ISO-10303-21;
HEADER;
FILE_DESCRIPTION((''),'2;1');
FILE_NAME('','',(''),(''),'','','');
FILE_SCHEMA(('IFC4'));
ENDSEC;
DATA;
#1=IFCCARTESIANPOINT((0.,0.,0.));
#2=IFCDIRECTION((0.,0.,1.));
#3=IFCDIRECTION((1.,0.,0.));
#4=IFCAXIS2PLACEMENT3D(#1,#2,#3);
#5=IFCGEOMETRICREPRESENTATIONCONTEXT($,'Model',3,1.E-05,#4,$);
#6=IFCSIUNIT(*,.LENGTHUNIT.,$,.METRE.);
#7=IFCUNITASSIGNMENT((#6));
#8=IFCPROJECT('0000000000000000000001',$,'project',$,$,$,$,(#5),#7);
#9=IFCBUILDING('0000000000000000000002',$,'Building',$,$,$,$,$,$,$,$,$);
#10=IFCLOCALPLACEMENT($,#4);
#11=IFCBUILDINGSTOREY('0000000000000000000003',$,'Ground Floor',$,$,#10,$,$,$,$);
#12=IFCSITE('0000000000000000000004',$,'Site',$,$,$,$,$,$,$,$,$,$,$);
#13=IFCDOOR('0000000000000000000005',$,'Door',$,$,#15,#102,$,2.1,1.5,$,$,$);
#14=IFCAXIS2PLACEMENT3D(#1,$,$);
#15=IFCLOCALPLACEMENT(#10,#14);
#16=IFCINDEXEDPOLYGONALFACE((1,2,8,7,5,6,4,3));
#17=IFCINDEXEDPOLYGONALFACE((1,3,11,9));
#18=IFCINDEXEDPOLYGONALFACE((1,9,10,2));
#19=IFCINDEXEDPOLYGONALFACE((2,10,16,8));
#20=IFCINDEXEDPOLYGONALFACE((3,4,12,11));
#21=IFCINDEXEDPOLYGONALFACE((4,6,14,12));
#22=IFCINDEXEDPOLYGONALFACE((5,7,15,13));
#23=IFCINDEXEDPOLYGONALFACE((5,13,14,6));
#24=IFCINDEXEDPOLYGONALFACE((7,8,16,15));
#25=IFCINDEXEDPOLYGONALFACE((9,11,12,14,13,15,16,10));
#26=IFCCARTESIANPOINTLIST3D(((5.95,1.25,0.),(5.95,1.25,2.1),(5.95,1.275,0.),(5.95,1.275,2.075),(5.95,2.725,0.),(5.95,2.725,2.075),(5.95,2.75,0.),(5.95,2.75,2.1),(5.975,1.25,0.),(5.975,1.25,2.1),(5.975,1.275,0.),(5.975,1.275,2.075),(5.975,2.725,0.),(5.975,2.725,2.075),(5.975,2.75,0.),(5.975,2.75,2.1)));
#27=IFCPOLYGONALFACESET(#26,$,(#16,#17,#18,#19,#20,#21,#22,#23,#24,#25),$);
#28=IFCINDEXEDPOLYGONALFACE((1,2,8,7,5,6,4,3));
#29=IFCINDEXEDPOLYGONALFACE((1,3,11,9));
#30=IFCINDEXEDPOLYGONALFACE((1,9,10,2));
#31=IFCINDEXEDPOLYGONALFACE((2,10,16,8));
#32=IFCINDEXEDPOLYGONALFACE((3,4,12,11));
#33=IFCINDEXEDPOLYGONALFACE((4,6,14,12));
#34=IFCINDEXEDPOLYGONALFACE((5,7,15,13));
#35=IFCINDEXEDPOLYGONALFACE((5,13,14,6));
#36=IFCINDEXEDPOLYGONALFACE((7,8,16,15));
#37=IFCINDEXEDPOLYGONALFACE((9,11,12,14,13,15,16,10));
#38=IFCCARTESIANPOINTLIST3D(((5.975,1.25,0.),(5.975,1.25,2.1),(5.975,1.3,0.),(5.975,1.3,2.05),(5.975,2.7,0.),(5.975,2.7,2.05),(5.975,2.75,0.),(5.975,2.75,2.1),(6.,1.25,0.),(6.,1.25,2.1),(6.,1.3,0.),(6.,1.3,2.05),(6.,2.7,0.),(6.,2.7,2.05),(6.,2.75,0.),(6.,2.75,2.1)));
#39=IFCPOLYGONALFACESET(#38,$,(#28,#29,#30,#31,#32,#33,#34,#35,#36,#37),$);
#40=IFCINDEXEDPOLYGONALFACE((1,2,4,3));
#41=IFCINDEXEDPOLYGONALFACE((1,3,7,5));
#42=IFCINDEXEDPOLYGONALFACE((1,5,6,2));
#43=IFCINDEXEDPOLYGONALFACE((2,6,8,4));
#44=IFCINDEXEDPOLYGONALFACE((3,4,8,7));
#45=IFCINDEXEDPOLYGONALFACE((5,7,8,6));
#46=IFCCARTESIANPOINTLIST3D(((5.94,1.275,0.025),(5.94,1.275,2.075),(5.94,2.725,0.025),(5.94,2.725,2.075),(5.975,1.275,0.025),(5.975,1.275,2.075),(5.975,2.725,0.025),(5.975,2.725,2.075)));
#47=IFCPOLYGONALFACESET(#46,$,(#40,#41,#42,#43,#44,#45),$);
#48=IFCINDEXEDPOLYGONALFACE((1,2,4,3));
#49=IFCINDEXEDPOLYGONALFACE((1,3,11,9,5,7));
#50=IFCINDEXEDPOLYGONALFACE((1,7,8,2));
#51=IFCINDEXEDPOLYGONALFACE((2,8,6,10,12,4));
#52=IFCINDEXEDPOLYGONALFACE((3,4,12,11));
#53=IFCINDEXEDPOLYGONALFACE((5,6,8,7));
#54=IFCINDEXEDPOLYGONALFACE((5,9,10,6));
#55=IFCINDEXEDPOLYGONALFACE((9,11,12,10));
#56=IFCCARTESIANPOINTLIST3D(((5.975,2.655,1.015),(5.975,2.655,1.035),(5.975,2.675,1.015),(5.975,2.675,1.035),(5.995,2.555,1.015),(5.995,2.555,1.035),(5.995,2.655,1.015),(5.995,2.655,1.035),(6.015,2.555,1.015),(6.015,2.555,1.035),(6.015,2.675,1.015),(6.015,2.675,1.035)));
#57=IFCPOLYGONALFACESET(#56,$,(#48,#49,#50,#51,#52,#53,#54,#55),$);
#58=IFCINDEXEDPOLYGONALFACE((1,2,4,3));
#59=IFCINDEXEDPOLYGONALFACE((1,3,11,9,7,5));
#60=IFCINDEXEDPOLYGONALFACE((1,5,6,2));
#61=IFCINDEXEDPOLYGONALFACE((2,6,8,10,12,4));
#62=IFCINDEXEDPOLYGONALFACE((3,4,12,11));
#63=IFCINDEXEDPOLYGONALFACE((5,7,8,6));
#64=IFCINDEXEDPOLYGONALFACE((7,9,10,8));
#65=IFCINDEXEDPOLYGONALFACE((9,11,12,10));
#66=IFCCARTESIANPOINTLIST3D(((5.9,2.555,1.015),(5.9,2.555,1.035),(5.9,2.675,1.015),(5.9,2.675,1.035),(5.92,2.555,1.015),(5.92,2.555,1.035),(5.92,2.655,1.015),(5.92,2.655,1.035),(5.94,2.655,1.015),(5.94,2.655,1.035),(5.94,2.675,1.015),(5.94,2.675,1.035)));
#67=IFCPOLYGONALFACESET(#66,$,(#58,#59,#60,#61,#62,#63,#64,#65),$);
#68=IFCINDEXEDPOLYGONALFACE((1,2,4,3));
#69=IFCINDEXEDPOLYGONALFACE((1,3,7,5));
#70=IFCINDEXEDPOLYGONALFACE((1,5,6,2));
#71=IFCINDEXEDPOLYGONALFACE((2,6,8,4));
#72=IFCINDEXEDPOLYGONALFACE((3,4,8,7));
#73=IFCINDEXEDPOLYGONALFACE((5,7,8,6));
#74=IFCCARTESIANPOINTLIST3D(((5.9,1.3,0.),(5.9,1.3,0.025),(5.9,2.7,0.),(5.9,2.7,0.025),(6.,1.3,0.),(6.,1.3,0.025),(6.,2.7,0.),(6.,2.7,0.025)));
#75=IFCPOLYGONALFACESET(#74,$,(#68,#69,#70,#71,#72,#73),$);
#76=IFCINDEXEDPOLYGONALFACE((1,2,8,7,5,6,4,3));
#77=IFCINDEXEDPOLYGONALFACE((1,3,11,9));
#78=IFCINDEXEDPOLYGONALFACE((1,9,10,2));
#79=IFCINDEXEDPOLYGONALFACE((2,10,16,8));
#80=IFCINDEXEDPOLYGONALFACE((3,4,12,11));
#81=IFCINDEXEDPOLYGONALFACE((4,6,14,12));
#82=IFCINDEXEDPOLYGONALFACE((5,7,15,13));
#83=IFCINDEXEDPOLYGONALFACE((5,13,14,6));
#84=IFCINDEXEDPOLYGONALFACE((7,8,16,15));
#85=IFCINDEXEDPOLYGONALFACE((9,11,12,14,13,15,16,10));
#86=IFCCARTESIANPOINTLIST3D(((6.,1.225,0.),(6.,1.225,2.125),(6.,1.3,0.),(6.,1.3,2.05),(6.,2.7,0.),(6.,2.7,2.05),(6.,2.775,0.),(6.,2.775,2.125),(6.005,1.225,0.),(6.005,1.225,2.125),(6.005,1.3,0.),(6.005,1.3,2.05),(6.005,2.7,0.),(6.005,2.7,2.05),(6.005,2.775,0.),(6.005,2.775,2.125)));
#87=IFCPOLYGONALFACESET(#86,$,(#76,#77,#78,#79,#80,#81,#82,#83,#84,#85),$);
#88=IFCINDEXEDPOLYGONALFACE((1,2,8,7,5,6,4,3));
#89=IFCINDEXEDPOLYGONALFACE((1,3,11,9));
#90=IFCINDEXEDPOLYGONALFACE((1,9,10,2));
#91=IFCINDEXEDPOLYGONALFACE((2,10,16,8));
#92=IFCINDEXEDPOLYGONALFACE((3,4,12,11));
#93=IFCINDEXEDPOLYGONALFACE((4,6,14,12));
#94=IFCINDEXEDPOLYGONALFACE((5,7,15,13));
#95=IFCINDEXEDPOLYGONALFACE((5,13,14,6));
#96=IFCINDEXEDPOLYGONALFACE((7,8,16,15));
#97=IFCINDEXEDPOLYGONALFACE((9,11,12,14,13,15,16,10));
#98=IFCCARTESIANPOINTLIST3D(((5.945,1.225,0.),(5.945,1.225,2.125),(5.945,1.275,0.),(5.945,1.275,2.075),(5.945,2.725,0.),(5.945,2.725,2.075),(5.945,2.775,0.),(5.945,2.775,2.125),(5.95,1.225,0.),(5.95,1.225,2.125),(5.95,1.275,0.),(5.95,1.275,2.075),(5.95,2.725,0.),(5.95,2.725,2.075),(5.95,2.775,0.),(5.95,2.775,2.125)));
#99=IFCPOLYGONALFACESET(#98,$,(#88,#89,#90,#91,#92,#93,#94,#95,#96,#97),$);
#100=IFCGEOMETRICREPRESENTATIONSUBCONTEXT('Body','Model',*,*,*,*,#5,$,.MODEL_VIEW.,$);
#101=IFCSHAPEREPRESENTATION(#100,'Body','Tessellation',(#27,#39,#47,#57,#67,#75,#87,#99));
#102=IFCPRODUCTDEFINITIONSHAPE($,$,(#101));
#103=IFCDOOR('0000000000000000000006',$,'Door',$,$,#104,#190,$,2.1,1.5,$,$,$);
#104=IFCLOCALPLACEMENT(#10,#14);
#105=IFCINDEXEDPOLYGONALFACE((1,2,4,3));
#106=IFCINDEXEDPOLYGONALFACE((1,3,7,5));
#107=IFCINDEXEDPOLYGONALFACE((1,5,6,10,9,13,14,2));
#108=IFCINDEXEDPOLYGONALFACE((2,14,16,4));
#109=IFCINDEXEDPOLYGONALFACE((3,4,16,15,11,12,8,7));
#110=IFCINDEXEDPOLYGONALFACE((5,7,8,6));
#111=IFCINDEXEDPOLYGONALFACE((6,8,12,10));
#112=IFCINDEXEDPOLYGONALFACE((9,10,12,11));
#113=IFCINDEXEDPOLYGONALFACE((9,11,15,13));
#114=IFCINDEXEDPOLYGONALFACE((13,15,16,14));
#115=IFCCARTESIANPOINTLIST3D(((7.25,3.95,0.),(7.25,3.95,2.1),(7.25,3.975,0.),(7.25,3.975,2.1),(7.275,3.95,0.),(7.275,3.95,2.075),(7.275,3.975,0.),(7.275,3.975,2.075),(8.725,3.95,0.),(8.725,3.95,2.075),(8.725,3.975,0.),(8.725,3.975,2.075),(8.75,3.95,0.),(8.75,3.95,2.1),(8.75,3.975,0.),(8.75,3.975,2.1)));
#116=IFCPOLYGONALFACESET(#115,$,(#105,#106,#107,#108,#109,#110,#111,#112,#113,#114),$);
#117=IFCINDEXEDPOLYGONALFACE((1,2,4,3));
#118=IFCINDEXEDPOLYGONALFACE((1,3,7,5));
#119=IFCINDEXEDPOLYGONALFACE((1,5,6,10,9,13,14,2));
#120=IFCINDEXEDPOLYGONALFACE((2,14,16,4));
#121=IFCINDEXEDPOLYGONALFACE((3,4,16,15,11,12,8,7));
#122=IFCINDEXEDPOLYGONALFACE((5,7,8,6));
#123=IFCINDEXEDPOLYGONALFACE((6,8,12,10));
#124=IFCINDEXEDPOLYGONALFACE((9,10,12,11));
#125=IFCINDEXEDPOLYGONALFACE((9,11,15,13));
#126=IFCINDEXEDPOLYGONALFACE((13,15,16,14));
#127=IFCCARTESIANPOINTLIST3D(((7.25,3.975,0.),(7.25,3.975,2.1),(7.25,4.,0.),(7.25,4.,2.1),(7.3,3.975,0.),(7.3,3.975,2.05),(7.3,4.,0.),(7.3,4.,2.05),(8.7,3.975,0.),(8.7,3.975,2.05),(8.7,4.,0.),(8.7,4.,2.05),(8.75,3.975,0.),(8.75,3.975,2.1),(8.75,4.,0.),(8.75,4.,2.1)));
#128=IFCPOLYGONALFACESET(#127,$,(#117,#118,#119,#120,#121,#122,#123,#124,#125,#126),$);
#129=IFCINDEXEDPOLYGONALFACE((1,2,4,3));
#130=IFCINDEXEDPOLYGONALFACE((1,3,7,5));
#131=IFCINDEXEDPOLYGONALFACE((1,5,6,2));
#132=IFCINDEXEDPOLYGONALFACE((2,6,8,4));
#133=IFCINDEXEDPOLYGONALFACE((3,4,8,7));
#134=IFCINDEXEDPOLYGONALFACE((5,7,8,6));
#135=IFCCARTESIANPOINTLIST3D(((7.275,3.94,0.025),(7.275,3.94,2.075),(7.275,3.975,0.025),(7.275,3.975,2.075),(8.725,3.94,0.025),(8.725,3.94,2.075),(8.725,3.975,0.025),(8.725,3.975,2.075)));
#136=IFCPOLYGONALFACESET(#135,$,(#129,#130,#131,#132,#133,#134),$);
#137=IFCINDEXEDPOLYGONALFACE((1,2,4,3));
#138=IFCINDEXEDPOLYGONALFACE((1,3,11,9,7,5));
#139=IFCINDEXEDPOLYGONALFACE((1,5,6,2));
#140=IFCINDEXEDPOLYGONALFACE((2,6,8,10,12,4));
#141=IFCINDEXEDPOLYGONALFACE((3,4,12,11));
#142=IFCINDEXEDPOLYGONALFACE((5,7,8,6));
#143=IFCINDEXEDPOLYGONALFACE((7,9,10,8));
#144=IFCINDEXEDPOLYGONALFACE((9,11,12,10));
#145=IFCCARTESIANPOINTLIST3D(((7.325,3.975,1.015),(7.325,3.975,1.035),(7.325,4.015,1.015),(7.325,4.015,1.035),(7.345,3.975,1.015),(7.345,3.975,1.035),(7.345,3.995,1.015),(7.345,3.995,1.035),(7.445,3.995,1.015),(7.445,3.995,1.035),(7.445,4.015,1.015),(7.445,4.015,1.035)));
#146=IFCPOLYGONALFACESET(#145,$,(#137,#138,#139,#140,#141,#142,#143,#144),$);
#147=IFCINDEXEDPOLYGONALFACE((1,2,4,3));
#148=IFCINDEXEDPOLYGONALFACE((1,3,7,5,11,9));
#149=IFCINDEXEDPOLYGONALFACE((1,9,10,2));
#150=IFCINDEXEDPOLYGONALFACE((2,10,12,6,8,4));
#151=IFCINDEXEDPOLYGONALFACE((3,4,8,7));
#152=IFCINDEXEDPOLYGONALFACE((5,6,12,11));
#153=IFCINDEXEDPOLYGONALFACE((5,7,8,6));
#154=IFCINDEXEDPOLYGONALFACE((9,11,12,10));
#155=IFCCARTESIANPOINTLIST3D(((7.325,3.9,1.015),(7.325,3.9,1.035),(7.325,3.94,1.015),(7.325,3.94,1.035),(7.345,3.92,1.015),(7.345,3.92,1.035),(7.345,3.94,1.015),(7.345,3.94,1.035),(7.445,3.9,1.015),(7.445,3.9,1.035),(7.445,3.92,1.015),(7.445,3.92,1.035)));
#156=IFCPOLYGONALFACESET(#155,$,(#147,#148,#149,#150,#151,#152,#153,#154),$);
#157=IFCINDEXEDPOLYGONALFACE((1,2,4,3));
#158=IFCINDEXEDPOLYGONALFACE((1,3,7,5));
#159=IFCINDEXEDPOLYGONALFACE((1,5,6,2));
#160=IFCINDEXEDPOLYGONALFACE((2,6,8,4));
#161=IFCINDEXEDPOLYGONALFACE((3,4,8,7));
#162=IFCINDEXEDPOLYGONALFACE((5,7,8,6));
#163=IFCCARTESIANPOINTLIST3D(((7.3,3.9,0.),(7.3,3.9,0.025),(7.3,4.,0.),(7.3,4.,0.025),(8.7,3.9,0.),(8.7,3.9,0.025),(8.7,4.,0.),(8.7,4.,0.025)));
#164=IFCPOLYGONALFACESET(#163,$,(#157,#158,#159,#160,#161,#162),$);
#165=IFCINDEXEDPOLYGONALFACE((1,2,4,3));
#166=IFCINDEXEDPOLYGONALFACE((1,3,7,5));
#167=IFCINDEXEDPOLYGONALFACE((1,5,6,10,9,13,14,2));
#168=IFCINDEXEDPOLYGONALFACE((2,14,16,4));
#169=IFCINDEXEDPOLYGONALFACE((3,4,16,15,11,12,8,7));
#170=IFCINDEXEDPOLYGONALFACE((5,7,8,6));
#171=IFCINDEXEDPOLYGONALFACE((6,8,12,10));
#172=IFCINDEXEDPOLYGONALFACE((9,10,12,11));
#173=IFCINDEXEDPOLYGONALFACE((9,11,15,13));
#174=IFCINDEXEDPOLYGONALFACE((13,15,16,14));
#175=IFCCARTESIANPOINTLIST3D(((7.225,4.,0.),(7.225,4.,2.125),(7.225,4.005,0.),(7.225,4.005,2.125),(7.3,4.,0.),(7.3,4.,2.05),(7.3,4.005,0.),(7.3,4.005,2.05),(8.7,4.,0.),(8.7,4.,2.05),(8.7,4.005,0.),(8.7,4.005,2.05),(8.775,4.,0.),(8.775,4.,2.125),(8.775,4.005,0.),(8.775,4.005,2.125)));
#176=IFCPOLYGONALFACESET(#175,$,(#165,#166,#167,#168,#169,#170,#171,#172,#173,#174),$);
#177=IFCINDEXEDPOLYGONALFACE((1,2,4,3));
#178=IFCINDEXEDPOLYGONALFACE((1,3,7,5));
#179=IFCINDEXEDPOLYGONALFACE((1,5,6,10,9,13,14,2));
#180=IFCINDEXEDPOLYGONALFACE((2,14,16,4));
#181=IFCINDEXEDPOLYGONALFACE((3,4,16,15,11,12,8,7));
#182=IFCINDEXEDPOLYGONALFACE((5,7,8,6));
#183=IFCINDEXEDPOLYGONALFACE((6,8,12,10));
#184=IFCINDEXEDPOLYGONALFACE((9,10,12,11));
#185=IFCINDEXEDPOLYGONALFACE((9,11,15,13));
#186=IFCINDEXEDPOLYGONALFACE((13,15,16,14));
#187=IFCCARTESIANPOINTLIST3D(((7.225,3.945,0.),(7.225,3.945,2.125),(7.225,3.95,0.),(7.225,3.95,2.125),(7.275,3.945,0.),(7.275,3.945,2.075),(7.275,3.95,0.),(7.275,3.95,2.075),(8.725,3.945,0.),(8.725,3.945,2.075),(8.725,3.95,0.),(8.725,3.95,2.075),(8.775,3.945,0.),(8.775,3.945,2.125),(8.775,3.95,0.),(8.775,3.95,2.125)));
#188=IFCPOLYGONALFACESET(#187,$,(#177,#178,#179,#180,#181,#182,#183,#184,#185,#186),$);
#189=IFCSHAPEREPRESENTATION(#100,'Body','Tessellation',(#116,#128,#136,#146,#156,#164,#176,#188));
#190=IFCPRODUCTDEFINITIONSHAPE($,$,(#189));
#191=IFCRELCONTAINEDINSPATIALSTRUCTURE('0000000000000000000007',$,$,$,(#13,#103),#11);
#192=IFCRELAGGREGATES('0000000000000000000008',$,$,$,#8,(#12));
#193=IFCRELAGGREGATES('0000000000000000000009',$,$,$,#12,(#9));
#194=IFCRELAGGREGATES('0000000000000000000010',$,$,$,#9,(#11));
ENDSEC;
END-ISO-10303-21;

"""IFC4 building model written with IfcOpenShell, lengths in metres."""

from ifc_helpers import new_model, si_unit, frame, origin_with_axes, place, context, subcontext, project, spatial, line, indexed_curve, outline, extrude, element, save


model = new_model("IFC4")

# Units and contexts
model_context = context("Model", 3, precision=1e-05, world=origin_with_axes())
body_context = subcontext(model_context, "Body", "Model", "MODEL_VIEW")
ifc_project = project(units=[si_unit("LENGTHUNIT", "METRE")], contexts=[model_context])

# Site, building, storey
site = spatial("IfcSite", under=ifc_project, Name="Site")
building = spatial("IfcBuilding", under=site, Name="Building")
storey_placement = place(None, origin_with_axes())
storey = spatial("IfcBuildingStorey", under=building, at=storey_placement, Name="Ground Floor")

# Doors
door_1_placement = place(storey_placement, frame((6.0, 1.25, 0.0), z_axis=(0.0, 0.0, 1.0), x_axis=(0.0, 1.0, 0.0)))
element("IfcDoor", 1, at=door_1_placement, inside=storey, Name="Door", OverallHeight=2.1, OverallWidth=1.5, context=body_context, shape_type="SweptSolid", body=[
    extrude(outline(indexed_curve([(0.0, 0.0), (0.0, 2.1), (1.5, 2.1), (1.5, 0.0), (1.475, 0.0), (1.475, 2.075), (0.025, 2.075), (0.025, 0.0)], segments=[line(1, 2, 3, 4, 5, 6, 7, 8, 1)])), frame((0.0, 0.025, 0.0), z_axis=(0.0, -1.0, 0.0), x_axis=(1.0, 0.0, 0.0)), (0.0, 0.0, -1.0), 0.025),
    extrude(outline(indexed_curve([(0.0, 0.0), (0.0, 2.1), (1.5, 2.1), (1.5, 0.0), (1.45, 0.0), (1.45, 2.05), (0.05, 2.05), (0.05, 0.0)], segments=[line(1, 2, 3, 4, 5, 6, 7, 8, 1)])), frame((0.0, 0.0, 0.0), z_axis=(0.0, -1.0, 0.0), x_axis=(1.0, 0.0, 0.0)), (0.0, 0.0, -1.0), 0.025),
    extrude(outline(indexed_curve([(0.0, 0.0), (1.45, 0.0), (1.45, 0.035), (0.0, 0.035)], segments=[line(1, 2, 3, 4, 1)])), frame((0.025, 0.025, 0.025), z_axis=(0.0, 0.0, 1.0), x_axis=(1.0, 0.0, 0.0)), (0.0, 0.0, 1.0), 2.05),
    extrude(outline(indexed_curve([(0.0, 0.0), (0.0, -0.04), (-0.12, -0.04), (-0.12, -0.02), (-0.02, -0.02), (-0.02, 0.0)], segments=[line(1, 2, 3, 4, 5, 6, 1)])), frame((1.425, 0.025, 1.015), z_axis=(0.0, 0.0, 1.0), x_axis=(1.0, 0.0, 0.0)), (0.0, 0.0, 1.0), 0.02),
    extrude(outline(indexed_curve([(0.0, 0.0), (0.0, 0.04), (-0.12, 0.04), (-0.12, 0.02), (-0.02, 0.02), (-0.02, 0.0)], segments=[line(1, 2, 3, 4, 5, 6, 1)])), frame((1.425, 0.06, 1.015), z_axis=(0.0, 0.0, 1.0), x_axis=(1.0, 0.0, 0.0)), (0.0, 0.0, 1.0), 0.02),
    extrude(outline(indexed_curve([(0.0, 0.0), (1.4, 0.0), (1.4, 0.1), (0.0, 0.1)], segments=[line(1, 2, 3, 4, 1)])), frame((0.05, 0.0, 0.0), z_axis=(0.0, 0.0, 1.0), x_axis=(1.0, 0.0, 0.0)), (0.0, 0.0, 1.0), 0.025),
    extrude(outline(indexed_curve([(0.0, 0.0), (0.0, 2.125), (1.55, 2.125), (1.55, 0.0), (1.475, 0.0), (1.475, 2.05), (0.075, 2.05), (0.075, 0.0)], segments=[line(1, 2, 3, 4, 5, 6, 7, 8, 1)])), frame((-0.025, -0.005, 0.0), z_axis=(0.0, -1.0, 0.0), x_axis=(1.0, 0.0, 0.0)), (0.0, 0.0, -1.0), 0.005),
    extrude(outline(indexed_curve([(0.0, 0.0), (0.0, 2.125), (1.55, 2.125), (1.55, 0.0), (1.5, 0.0), (1.5, 2.075), (0.05, 2.075), (0.05, 0.0)], segments=[line(1, 2, 3, 4, 5, 6, 7, 8, 1)])), frame((-0.025, 0.05, 0.0), z_axis=(0.0, -1.0, 0.0), x_axis=(1.0, 0.0, 0.0)), (0.0, 0.0, -1.0), 0.005),
])
door_2_placement = place(storey_placement, frame((8.75, 4.0, 0.0), z_axis=(0.0, 0.0, 1.0), x_axis=(-1.0, 0.0, 0.0)))
element("IfcDoor", 2, at=door_2_placement, inside=storey, Name="Door", OverallHeight=2.1, OverallWidth=1.5, context=body_context, shape_type="SweptSolid", body=[
    extrude(outline(indexed_curve([(0.0, 0.0), (0.0, 2.1), (1.5, 2.1), (1.5, 0.0), (1.475, 0.0), (1.475, 2.075), (0.025, 2.075), (0.025, 0.0)], segments=[line(1, 2, 3, 4, 5, 6, 7, 8, 1)])), frame((0.0, 0.025, 0.0), z_axis=(0.0, -1.0, 0.0), x_axis=(1.0, 0.0, 0.0)), (0.0, 0.0, -1.0), 0.025),
    extrude(outline(indexed_curve([(0.0, 0.0), (0.0, 2.1), (1.5, 2.1), (1.5, 0.0), (1.45, 0.0), (1.45, 2.05), (0.05, 2.05), (0.05, 0.0)], segments=[line(1, 2, 3, 4, 5, 6, 7, 8, 1)])), frame((0.0, 0.0, 0.0), z_axis=(0.0, -1.0, 0.0), x_axis=(1.0, 0.0, 0.0)), (0.0, 0.0, -1.0), 0.025),
    extrude(outline(indexed_curve([(0.0, 0.0), (1.45, 0.0), (1.45, 0.035), (0.0, 0.035)], segments=[line(1, 2, 3, 4, 1)])), frame((0.025, 0.025, 0.025), z_axis=(0.0, 0.0, 1.0), x_axis=(1.0, 0.0, 0.0)), (0.0, 0.0, 1.0), 2.05),
    extrude(outline(indexed_curve([(0.0, 0.0), (0.0, -0.04), (-0.12, -0.04), (-0.12, -0.02), (-0.02, -0.02), (-0.02, 0.0)], segments=[line(1, 2, 3, 4, 5, 6, 1)])), frame((1.425, 0.025, 1.015), z_axis=(0.0, 0.0, 1.0), x_axis=(1.0, 0.0, 0.0)), (0.0, 0.0, 1.0), 0.02),
    extrude(outline(indexed_curve([(0.0, 0.0), (0.0, 0.04), (-0.12, 0.04), (-0.12, 0.02), (-0.02, 0.02), (-0.02, 0.0)], segments=[line(1, 2, 3, 4, 5, 6, 1)])), frame((1.425, 0.06, 1.015), z_axis=(0.0, 0.0, 1.0), x_axis=(1.0, 0.0, 0.0)), (0.0, 0.0, 1.0), 0.02),
    extrude(outline(indexed_curve([(0.0, 0.0), (1.4, 0.0), (1.4, 0.1), (0.0, 0.1)], segments=[line(1, 2, 3, 4, 1)])), frame((0.05, 0.0, 0.0), z_axis=(0.0, 0.0, 1.0), x_axis=(1.0, 0.0, 0.0)), (0.0, 0.0, 1.0), 0.025),
    extrude(outline(indexed_curve([(0.0, 0.0), (0.0, 2.125), (1.55, 2.125), (1.55, 0.0), (1.475, 0.0), (1.475, 2.05), (0.075, 2.05), (0.075, 0.0)], segments=[line(1, 2, 3, 4, 5, 6, 7, 8, 1)])), frame((-0.025, -0.005, 0.0), z_axis=(0.0, -1.0, 0.0), x_axis=(1.0, 0.0, 0.0)), (0.0, 0.0, -1.0), 0.005),
    extrude(outline(indexed_curve([(0.0, 0.0), (0.0, 2.125), (1.55, 2.125), (1.55, 0.0), (1.5, 0.0), (1.5, 2.075), (0.05, 2.075), (0.05, 0.0)], segments=[line(1, 2, 3, 4, 5, 6, 7, 8, 1)])), frame((-0.025, 0.05, 0.0), z_axis=(0.0, -1.0, 0.0), x_axis=(1.0, 0.0, 0.0)), (0.0, 0.0, -1.0), 0.005),
])

save(model, "model.ifc")
